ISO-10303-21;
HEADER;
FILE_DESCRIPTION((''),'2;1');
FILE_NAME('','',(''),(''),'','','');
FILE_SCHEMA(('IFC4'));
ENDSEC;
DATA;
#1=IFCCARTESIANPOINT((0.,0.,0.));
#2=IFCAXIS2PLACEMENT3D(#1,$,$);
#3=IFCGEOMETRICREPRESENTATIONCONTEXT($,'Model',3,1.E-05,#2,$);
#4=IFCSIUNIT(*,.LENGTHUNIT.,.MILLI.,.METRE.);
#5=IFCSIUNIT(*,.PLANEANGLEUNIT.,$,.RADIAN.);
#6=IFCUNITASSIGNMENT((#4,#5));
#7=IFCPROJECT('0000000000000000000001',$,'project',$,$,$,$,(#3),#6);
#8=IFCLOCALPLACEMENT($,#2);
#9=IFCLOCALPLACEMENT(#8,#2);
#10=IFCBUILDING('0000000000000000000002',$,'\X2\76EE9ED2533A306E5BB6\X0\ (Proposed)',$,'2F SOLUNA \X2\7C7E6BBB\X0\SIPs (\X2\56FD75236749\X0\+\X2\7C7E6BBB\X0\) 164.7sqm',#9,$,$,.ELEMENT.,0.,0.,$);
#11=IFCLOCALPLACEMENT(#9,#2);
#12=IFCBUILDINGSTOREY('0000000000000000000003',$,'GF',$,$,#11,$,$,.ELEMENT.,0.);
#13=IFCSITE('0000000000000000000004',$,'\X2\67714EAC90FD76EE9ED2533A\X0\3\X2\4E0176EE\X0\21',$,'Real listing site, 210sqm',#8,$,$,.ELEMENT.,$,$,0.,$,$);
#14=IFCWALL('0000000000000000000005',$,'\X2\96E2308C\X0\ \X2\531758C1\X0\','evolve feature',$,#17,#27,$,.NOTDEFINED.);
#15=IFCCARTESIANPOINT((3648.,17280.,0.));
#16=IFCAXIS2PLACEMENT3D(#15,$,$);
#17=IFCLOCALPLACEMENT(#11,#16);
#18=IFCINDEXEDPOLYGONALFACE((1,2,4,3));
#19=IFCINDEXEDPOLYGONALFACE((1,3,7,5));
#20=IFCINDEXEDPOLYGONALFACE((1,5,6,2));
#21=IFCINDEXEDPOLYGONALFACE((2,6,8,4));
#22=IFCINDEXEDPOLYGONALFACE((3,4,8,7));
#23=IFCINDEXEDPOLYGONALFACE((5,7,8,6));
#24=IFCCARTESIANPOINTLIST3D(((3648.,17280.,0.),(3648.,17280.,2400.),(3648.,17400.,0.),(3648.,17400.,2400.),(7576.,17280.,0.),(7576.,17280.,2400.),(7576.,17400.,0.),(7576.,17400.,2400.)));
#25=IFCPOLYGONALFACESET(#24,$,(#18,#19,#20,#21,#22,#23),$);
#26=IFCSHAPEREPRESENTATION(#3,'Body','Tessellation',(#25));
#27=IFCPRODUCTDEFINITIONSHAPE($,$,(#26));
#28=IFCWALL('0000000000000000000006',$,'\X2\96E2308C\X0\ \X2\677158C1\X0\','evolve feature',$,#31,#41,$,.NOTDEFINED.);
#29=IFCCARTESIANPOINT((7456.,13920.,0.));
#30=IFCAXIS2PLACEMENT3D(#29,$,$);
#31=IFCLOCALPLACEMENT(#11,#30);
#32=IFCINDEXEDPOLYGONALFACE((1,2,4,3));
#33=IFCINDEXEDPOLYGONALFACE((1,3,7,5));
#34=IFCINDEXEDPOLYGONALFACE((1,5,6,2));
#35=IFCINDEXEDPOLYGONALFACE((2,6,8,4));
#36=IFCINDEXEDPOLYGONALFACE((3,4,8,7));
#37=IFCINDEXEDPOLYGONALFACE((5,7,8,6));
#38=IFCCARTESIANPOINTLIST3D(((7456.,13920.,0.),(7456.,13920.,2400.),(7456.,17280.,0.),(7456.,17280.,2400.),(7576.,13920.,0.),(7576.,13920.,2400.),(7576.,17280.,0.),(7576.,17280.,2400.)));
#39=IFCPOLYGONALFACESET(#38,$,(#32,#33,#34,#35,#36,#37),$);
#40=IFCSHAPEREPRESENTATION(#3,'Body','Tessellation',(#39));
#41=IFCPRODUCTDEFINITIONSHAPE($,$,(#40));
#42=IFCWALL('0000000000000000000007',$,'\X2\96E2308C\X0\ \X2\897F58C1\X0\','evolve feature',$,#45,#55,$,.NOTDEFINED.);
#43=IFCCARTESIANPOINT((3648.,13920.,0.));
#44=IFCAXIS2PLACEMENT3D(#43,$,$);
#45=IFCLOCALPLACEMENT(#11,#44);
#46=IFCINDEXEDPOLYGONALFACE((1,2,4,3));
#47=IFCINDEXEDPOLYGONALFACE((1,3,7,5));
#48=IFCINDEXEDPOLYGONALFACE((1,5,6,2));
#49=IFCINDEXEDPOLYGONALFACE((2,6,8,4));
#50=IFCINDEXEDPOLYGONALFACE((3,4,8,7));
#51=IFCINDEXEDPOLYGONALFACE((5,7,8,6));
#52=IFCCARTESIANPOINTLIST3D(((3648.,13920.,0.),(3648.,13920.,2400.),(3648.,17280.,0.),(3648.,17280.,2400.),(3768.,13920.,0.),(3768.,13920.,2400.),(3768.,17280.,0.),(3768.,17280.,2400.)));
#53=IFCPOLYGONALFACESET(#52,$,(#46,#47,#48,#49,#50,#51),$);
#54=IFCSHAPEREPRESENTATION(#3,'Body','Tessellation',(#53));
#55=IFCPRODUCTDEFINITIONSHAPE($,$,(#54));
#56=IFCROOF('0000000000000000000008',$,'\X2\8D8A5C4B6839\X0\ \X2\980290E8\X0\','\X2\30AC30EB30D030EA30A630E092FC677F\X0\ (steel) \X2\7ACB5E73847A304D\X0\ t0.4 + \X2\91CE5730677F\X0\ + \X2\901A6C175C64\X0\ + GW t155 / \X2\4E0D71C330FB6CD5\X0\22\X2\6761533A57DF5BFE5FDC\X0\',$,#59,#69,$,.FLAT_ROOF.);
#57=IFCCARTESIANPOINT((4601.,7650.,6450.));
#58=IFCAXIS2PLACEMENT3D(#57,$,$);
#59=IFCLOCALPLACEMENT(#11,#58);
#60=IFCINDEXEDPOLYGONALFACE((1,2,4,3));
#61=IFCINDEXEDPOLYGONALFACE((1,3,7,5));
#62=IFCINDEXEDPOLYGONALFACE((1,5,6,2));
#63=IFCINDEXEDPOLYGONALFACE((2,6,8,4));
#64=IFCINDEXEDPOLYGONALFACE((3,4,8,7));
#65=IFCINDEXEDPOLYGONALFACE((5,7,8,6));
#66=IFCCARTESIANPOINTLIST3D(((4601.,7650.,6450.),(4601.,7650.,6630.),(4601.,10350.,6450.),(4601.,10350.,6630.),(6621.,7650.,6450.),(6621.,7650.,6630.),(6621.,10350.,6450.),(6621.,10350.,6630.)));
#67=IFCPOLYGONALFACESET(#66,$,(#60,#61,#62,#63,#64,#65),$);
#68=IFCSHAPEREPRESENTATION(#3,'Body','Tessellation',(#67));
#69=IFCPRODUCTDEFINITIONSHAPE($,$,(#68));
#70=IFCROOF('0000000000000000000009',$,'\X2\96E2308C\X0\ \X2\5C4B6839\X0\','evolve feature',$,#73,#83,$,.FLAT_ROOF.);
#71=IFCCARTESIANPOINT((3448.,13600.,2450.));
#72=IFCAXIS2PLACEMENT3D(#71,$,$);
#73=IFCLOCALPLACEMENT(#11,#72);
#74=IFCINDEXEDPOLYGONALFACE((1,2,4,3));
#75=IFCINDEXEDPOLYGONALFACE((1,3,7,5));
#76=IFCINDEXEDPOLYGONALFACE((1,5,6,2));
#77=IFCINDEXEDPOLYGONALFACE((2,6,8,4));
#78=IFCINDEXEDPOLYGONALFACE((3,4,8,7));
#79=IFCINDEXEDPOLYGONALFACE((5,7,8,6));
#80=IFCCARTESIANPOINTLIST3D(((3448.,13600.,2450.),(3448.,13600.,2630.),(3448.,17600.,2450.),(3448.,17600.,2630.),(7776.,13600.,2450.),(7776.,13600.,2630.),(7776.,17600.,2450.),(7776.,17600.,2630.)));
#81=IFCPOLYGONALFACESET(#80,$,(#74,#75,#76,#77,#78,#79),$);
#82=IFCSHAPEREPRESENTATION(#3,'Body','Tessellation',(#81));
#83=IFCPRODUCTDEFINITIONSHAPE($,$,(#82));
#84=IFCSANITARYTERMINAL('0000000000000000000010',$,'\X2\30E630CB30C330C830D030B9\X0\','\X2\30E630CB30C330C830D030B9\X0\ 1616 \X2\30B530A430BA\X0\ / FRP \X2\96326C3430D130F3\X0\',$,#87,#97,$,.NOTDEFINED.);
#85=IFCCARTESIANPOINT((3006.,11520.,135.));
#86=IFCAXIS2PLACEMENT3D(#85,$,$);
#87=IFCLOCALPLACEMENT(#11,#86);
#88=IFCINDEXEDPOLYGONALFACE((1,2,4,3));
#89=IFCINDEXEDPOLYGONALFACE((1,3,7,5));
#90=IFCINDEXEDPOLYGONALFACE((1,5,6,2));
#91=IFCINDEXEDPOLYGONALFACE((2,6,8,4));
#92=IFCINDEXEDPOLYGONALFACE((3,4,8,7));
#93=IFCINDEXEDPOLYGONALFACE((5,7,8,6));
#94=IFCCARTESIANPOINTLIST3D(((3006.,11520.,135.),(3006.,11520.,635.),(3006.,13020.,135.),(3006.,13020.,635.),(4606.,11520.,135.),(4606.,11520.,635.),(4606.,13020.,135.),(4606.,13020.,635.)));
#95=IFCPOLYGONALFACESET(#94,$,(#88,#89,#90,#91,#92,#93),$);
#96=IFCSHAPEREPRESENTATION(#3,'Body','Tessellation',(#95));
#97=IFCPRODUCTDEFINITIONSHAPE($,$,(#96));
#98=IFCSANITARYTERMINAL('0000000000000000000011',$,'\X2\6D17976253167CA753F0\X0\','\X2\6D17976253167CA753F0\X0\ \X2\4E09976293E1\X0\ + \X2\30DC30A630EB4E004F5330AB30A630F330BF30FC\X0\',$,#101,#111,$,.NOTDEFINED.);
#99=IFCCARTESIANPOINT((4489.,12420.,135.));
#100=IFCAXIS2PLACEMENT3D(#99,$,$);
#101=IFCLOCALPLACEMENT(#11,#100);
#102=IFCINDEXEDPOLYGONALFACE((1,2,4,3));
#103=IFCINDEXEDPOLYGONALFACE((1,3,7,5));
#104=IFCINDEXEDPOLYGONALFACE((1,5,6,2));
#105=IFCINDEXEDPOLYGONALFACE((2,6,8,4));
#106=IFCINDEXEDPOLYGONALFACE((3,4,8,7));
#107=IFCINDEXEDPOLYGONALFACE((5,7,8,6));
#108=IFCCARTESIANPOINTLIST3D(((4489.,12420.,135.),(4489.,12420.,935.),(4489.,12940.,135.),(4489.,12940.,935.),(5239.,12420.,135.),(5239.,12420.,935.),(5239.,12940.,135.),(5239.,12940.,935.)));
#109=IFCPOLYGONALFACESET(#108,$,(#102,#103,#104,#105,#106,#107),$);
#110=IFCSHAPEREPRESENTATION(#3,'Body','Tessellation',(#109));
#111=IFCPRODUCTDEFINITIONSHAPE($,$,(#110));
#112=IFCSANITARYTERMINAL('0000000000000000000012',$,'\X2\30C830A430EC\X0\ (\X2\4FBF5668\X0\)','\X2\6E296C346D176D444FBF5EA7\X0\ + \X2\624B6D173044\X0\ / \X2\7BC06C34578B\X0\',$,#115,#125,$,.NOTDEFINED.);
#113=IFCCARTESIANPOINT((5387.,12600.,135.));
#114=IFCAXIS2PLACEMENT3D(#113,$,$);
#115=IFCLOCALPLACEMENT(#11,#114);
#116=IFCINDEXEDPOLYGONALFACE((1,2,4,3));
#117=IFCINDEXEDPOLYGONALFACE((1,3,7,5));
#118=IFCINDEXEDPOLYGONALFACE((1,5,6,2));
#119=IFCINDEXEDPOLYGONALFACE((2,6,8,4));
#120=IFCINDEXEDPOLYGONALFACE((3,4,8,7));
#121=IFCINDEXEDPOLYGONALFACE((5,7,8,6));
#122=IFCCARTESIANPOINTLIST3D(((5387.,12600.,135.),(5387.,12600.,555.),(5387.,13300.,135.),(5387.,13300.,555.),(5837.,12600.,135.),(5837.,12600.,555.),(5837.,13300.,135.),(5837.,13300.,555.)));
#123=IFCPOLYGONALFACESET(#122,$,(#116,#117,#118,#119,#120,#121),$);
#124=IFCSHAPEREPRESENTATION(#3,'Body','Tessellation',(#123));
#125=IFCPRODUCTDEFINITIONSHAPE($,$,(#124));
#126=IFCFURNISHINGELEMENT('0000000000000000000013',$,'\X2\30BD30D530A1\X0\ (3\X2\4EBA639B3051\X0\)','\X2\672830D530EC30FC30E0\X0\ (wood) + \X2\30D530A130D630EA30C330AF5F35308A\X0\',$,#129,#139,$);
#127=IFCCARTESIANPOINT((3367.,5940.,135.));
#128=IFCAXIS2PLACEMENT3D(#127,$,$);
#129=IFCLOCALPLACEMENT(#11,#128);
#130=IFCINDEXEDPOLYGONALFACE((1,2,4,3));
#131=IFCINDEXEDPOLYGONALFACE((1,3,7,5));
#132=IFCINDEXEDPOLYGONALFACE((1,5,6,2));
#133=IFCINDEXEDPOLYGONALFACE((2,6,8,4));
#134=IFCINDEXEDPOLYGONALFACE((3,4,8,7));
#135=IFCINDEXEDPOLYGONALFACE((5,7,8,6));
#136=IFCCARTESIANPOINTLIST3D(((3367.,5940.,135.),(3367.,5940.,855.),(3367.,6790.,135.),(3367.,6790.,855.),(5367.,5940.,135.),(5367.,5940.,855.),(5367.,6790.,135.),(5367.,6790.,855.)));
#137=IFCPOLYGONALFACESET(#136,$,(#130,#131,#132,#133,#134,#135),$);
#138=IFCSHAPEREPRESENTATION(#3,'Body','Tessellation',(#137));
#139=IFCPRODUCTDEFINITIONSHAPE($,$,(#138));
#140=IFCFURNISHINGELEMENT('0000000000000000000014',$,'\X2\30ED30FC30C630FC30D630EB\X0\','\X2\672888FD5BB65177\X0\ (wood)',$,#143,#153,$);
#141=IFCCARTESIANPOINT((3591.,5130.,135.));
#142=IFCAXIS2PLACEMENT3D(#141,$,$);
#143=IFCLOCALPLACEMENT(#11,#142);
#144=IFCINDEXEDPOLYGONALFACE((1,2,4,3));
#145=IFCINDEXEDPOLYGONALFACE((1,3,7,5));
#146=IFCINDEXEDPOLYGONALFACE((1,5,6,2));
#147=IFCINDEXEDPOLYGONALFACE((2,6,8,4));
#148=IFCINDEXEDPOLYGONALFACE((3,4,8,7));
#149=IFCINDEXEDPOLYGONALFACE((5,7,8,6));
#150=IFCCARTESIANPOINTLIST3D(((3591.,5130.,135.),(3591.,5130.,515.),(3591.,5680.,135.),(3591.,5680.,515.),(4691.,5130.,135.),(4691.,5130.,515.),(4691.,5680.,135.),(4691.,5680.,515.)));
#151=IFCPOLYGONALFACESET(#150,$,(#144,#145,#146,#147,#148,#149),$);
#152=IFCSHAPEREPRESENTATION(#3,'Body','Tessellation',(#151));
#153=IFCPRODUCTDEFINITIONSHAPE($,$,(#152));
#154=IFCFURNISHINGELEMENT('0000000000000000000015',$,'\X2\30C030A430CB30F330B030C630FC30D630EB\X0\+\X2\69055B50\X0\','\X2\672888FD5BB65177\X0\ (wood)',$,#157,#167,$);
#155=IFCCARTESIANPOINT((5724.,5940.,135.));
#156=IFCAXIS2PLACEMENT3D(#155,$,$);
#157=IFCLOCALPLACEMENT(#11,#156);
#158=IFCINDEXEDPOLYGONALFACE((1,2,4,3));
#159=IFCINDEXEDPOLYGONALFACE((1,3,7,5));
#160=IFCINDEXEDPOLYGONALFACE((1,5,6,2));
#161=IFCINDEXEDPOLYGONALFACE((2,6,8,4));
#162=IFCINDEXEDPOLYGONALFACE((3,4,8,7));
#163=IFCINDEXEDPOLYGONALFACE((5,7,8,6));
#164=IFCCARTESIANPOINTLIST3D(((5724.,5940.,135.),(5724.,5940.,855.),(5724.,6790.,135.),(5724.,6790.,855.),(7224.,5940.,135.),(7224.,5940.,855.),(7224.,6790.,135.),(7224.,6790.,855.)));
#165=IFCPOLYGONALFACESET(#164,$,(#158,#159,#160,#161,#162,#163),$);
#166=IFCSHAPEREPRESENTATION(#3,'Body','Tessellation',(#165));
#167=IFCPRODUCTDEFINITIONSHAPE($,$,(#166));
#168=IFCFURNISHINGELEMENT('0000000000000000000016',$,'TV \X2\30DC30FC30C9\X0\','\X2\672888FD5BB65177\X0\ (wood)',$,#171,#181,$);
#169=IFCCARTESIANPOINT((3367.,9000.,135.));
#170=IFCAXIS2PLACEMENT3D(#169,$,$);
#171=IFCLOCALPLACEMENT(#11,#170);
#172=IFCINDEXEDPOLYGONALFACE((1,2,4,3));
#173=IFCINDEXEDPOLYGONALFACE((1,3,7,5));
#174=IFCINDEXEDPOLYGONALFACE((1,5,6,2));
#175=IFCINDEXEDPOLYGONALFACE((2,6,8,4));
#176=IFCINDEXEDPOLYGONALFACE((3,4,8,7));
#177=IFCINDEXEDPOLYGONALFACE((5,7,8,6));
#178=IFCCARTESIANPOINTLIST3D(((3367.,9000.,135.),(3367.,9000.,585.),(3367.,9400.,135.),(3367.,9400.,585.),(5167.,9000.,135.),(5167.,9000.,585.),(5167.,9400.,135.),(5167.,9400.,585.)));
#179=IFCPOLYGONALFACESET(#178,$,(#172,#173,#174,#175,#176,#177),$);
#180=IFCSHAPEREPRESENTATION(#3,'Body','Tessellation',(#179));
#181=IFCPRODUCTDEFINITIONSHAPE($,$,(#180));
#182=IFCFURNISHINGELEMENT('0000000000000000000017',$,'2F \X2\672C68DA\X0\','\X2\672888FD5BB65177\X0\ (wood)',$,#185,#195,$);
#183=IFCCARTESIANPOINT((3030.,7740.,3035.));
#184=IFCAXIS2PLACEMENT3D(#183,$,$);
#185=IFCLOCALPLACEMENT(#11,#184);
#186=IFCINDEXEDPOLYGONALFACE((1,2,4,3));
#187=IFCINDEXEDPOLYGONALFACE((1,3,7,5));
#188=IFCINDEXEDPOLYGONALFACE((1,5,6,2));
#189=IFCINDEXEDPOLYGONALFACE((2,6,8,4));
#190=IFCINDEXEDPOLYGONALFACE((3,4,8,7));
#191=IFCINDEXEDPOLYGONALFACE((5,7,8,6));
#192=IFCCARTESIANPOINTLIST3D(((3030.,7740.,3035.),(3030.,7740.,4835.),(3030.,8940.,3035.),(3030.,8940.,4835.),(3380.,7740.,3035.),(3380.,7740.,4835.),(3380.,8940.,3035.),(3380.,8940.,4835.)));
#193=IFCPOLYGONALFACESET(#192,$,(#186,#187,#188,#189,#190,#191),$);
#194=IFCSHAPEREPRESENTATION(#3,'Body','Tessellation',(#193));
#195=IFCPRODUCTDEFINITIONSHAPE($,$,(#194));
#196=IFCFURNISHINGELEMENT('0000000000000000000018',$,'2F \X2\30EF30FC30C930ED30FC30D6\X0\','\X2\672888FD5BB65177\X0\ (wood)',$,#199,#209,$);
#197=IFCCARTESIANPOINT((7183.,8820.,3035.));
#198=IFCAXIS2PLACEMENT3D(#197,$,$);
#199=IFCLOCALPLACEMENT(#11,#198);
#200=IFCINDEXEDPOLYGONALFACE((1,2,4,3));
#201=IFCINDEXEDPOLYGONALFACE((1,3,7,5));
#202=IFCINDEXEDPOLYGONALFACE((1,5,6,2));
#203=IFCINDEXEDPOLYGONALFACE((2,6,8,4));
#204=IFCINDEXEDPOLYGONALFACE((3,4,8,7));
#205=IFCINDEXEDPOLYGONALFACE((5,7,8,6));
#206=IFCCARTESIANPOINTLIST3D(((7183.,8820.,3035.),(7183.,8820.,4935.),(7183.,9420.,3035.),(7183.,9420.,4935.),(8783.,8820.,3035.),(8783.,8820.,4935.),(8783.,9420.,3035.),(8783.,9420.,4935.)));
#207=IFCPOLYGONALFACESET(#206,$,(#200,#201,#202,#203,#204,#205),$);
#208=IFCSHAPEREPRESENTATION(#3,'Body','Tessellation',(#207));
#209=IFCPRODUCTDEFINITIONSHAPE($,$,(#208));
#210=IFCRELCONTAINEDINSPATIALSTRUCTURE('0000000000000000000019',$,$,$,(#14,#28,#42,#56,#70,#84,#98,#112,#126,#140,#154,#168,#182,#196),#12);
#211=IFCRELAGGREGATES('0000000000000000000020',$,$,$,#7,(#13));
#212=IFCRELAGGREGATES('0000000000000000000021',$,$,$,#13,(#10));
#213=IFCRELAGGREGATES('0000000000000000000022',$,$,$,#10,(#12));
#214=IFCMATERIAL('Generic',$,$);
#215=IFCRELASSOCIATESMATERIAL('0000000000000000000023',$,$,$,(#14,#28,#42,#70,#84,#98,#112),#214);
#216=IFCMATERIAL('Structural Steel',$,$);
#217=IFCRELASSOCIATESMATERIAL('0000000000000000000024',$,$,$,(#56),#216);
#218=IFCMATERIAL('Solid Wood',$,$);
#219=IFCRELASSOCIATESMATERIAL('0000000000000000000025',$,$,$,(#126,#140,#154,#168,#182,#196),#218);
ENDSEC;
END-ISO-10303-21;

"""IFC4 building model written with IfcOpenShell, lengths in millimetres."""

from ifc_helpers import new_model, si_unit, frame, frame_2d, origin, place, context, project, spatial, rectangle, extrude, material, element, save


model = new_model("IFC4")

# Units and contexts
model_context = context("Model", 3, precision=1e-05, world=origin())
ifc_project = project(units=[si_unit("LENGTHUNIT", "METRE", prefix="MILLI"), si_unit("PLANEANGLEUNIT", "RADIAN")], contexts=[model_context])

# Site, building, storey
site_placement = place(None, origin())
site = spatial("IfcSite", under=ifc_project, at=site_placement, Name="東京都目黒区3丁目21", ObjectType="Real listing site, 210sqm", CompositionType="ELEMENT", RefElevation=0.0)
building_placement = place(site_placement, origin())
building = spatial("IfcBuilding", under=site, at=building_placement, Name="目黒区の家 (Proposed)", ObjectType="2F SOLUNA 籾殻SIPs (国産杉+籾殻) 164.7sqm", CompositionType="ELEMENT", ElevationOfRefHeight=0.0, ElevationOfTerrain=0.0)
storey_placement = place(building_placement, origin())
storey = spatial("IfcBuildingStorey", under=building, at=storey_placement, Name="GF", CompositionType="ELEMENT", Elevation=0.0)

# Shared definitions
ifc_material_1 = material(Name="Generic")

# Shared definitions
ifc_material_2 = material(Name="Solid Wood")

# Walls
wall_1_placement = place(storey_placement, frame((3648.0, 17280.0, 0.0)))
element("IfcWall", 1, at=wall_1_placement, inside=storey, material=ifc_material_1, Name="離れ 北壁", Description="evolve feature", PredefinedType="NOTDEFINED", context=model_context, shape_type="SweptSolid", body=[
    extrude(rectangle(XDim=3928.0, YDim=120.0, at=frame_2d((1964.0, 60.0))), frame((3648.0, 17280.0, 0.0)), (0.0, 0.0, 1.0), 2400.0),
])
wall_2_placement = place(storey_placement, frame((7456.0, 13920.0, 0.0)))
element("IfcWall", 2, at=wall_2_placement, inside=storey, material=ifc_material_1, Name="離れ 東壁", Description="evolve feature", PredefinedType="NOTDEFINED", context=model_context, shape_type="SweptSolid", body=[
    extrude(rectangle(XDim=120.0, YDim=3360.0, at=frame_2d((60.0, 1680.0))), frame((7456.0, 13920.0, 0.0)), (0.0, 0.0, 1.0), 2400.0),
])
wall_3_placement = place(storey_placement, frame((3648.0, 13920.0, 0.0)))
element("IfcWall", 3, at=wall_3_placement, inside=storey, material=ifc_material_1, Name="離れ 西壁", Description="evolve feature", PredefinedType="NOTDEFINED", context=model_context, shape_type="SweptSolid", body=[
    extrude(rectangle(XDim=120.0, YDim=3360.0, at=frame_2d((60.0, 1680.0))), frame((3648.0, 13920.0, 0.0)), (0.0, 0.0, 1.0), 2400.0),
])

# Roofs
ifc_material_3 = material(Name="Structural Steel")
roof_1_placement = place(storey_placement, frame((4601.0, 7650.0, 6450.0)))
element("IfcRoof", 4, at=roof_1_placement, inside=storey, material=ifc_material_3, Name="越屋根 頂部", Description="ガルバリウム鋼板 (steel) 立平葺き t0.4 + 野地板 + 通気層 + GW t155 / 不燃・法22条区域対応", PredefinedType="FLAT_ROOF", context=model_context, shape_type="SweptSolid", body=[
    extrude(rectangle(XDim=2020.0, YDim=2700.0, at=frame_2d((1010.0, 1350.0))), frame((4601.0, 7650.0, 6450.0)), (0.0, 0.0, 1.0), 180.0),
])
roof_2_placement = place(storey_placement, frame((3448.0, 13600.0, 2450.0)))
element("IfcRoof", 5, at=roof_2_placement, inside=storey, material=ifc_material_1, Name="離れ 屋根", Description="evolve feature", PredefinedType="FLAT_ROOF", context=model_context, shape_type="SweptSolid", body=[
    extrude(rectangle(XDim=4328.0, YDim=4000.0, at=frame_2d((2164.0, 2000.0))), frame((3448.0, 13600.0, 2450.0)), (0.0, 0.0, 1.0), 180.0),
])

# Sanitary terminals
sanitary_terminal_1_placement = place(storey_placement, frame((3006.0, 11520.0, 135.0)))
element("IfcSanitaryTerminal", 6, at=sanitary_terminal_1_placement, inside=storey, material=ifc_material_1, Name="ユニットバス", Description="ユニットバス 1616 サイズ / FRP 防水パン", PredefinedType="NOTDEFINED", context=model_context, shape_type="SweptSolid", body=[
    extrude(rectangle(XDim=1600.0, YDim=1500.0, at=frame_2d((800.0, 750.0))), frame((3006.0, 11520.0, 135.0)), (0.0, 0.0, 1.0), 500.0),
])
sanitary_terminal_2_placement = place(storey_placement, frame((4489.0, 12420.0, 135.0)))
element("IfcSanitaryTerminal", 7, at=sanitary_terminal_2_placement, inside=storey, material=ifc_material_1, Name="洗面化粧台", Description="洗面化粧台 三面鏡 + ボウル一体カウンター", PredefinedType="NOTDEFINED", context=model_context, shape_type="SweptSolid", body=[
    extrude(rectangle(XDim=750.0, YDim=520.0, at=frame_2d((375.0, 260.0))), frame((4489.0, 12420.0, 135.0)), (0.0, 0.0, 1.0), 800.0),
])
sanitary_terminal_3_placement = place(storey_placement, frame((5387.0, 12600.0, 135.0)))
element("IfcSanitaryTerminal", 8, at=sanitary_terminal_3_placement, inside=storey, material=ifc_material_1, Name="トイレ (便器)", Description="温水洗浄便座 + 手洗い / 節水型", PredefinedType="NOTDEFINED", context=model_context, shape_type="SweptSolid", body=[
    extrude(rectangle(XDim=450.0, YDim=700.0, at=frame_2d((225.0, 350.0))), frame((5387.0, 12600.0, 135.0)), (0.0, 0.0, 1.0), 420.0),
])

# Furnishing elements
furnishing_1_placement = place(storey_placement, frame((3367.0, 5940.0, 135.0)))
element("IfcFurnishingElement", 9, at=furnishing_1_placement, inside=storey, material=ifc_material_2, Name="ソファ (3人掛け)", Description="木フレーム (wood) + ファブリック張り", context=model_context, shape_type="SweptSolid", body=[
    extrude(rectangle(XDim=2000.0, YDim=850.0, at=frame_2d((1000.0, 425.0))), frame((3367.0, 5940.0, 135.0)), (0.0, 0.0, 1.0), 720.0),
])
furnishing_2_placement = place(storey_placement, frame((3591.0, 5130.0, 135.0)))
element("IfcFurnishingElement", 10, at=furnishing_2_placement, inside=storey, material=ifc_material_2, Name="ローテーブル", Description="木製家具 (wood)", context=model_context, shape_type="SweptSolid", body=[
    extrude(rectangle(XDim=1100.0, YDim=550.0, at=frame_2d((550.0, 275.0))), frame((3591.0, 5130.0, 135.0)), (0.0, 0.0, 1.0), 380.0),
])
furnishing_3_placement = place(storey_placement, frame((5724.0, 5940.0, 135.0)))
element("IfcFurnishingElement", 11, at=furnishing_3_placement, inside=storey, material=ifc_material_2, Name="ダイニングテーブル+椅子", Description="木製家具 (wood)", context=model_context, shape_type="SweptSolid", body=[
    extrude(rectangle(XDim=1500.0, YDim=850.0, at=frame_2d((750.0, 425.0))), frame((5724.0, 5940.0, 135.0)), (0.0, 0.0, 1.0), 720.0),
])
furnishing_4_placement = place(storey_placement, frame((3367.0, 9000.0, 135.0)))
element("IfcFurnishingElement", 12, at=furnishing_4_placement, inside=storey, material=ifc_material_2, Name="TV ボード", Description="木製家具 (wood)", context=model_context, shape_type="SweptSolid", body=[
    extrude(rectangle(XDim=1800.0, YDim=400.0, at=frame_2d((900.0, 200.0))), frame((3367.0, 9000.0, 135.0)), (0.0, 0.0, 1.0), 450.0),
])
furnishing_5_placement = place(storey_placement, frame((3030.0, 7740.0, 3035.0)))
element("IfcFurnishingElement", 13, at=furnishing_5_placement, inside=storey, material=ifc_material_2, Name="2F 本棚", Description="木製家具 (wood)", context=model_context, shape_type="SweptSolid", body=[
    extrude(rectangle(XDim=350.0, YDim=1200.0, at=frame_2d((175.0, 600.0))), frame((3030.0, 7740.0, 3035.0)), (0.0, 0.0, 1.0), 1800.0),
])
furnishing_6_placement = place(storey_placement, frame((7183.0, 8820.0, 3035.0)))
element("IfcFurnishingElement", 14, at=furnishing_6_placement, inside=storey, material=ifc_material_2, Name="2F ワードローブ", Description="木製家具 (wood)", context=model_context, shape_type="SweptSolid", body=[
    extrude(rectangle(XDim=1600.0, YDim=600.0, at=frame_2d((800.0, 300.0))), frame((7183.0, 8820.0, 3035.0)), (0.0, 0.0, 1.0), 1900.0),
])

save(model, "model.ifc")
